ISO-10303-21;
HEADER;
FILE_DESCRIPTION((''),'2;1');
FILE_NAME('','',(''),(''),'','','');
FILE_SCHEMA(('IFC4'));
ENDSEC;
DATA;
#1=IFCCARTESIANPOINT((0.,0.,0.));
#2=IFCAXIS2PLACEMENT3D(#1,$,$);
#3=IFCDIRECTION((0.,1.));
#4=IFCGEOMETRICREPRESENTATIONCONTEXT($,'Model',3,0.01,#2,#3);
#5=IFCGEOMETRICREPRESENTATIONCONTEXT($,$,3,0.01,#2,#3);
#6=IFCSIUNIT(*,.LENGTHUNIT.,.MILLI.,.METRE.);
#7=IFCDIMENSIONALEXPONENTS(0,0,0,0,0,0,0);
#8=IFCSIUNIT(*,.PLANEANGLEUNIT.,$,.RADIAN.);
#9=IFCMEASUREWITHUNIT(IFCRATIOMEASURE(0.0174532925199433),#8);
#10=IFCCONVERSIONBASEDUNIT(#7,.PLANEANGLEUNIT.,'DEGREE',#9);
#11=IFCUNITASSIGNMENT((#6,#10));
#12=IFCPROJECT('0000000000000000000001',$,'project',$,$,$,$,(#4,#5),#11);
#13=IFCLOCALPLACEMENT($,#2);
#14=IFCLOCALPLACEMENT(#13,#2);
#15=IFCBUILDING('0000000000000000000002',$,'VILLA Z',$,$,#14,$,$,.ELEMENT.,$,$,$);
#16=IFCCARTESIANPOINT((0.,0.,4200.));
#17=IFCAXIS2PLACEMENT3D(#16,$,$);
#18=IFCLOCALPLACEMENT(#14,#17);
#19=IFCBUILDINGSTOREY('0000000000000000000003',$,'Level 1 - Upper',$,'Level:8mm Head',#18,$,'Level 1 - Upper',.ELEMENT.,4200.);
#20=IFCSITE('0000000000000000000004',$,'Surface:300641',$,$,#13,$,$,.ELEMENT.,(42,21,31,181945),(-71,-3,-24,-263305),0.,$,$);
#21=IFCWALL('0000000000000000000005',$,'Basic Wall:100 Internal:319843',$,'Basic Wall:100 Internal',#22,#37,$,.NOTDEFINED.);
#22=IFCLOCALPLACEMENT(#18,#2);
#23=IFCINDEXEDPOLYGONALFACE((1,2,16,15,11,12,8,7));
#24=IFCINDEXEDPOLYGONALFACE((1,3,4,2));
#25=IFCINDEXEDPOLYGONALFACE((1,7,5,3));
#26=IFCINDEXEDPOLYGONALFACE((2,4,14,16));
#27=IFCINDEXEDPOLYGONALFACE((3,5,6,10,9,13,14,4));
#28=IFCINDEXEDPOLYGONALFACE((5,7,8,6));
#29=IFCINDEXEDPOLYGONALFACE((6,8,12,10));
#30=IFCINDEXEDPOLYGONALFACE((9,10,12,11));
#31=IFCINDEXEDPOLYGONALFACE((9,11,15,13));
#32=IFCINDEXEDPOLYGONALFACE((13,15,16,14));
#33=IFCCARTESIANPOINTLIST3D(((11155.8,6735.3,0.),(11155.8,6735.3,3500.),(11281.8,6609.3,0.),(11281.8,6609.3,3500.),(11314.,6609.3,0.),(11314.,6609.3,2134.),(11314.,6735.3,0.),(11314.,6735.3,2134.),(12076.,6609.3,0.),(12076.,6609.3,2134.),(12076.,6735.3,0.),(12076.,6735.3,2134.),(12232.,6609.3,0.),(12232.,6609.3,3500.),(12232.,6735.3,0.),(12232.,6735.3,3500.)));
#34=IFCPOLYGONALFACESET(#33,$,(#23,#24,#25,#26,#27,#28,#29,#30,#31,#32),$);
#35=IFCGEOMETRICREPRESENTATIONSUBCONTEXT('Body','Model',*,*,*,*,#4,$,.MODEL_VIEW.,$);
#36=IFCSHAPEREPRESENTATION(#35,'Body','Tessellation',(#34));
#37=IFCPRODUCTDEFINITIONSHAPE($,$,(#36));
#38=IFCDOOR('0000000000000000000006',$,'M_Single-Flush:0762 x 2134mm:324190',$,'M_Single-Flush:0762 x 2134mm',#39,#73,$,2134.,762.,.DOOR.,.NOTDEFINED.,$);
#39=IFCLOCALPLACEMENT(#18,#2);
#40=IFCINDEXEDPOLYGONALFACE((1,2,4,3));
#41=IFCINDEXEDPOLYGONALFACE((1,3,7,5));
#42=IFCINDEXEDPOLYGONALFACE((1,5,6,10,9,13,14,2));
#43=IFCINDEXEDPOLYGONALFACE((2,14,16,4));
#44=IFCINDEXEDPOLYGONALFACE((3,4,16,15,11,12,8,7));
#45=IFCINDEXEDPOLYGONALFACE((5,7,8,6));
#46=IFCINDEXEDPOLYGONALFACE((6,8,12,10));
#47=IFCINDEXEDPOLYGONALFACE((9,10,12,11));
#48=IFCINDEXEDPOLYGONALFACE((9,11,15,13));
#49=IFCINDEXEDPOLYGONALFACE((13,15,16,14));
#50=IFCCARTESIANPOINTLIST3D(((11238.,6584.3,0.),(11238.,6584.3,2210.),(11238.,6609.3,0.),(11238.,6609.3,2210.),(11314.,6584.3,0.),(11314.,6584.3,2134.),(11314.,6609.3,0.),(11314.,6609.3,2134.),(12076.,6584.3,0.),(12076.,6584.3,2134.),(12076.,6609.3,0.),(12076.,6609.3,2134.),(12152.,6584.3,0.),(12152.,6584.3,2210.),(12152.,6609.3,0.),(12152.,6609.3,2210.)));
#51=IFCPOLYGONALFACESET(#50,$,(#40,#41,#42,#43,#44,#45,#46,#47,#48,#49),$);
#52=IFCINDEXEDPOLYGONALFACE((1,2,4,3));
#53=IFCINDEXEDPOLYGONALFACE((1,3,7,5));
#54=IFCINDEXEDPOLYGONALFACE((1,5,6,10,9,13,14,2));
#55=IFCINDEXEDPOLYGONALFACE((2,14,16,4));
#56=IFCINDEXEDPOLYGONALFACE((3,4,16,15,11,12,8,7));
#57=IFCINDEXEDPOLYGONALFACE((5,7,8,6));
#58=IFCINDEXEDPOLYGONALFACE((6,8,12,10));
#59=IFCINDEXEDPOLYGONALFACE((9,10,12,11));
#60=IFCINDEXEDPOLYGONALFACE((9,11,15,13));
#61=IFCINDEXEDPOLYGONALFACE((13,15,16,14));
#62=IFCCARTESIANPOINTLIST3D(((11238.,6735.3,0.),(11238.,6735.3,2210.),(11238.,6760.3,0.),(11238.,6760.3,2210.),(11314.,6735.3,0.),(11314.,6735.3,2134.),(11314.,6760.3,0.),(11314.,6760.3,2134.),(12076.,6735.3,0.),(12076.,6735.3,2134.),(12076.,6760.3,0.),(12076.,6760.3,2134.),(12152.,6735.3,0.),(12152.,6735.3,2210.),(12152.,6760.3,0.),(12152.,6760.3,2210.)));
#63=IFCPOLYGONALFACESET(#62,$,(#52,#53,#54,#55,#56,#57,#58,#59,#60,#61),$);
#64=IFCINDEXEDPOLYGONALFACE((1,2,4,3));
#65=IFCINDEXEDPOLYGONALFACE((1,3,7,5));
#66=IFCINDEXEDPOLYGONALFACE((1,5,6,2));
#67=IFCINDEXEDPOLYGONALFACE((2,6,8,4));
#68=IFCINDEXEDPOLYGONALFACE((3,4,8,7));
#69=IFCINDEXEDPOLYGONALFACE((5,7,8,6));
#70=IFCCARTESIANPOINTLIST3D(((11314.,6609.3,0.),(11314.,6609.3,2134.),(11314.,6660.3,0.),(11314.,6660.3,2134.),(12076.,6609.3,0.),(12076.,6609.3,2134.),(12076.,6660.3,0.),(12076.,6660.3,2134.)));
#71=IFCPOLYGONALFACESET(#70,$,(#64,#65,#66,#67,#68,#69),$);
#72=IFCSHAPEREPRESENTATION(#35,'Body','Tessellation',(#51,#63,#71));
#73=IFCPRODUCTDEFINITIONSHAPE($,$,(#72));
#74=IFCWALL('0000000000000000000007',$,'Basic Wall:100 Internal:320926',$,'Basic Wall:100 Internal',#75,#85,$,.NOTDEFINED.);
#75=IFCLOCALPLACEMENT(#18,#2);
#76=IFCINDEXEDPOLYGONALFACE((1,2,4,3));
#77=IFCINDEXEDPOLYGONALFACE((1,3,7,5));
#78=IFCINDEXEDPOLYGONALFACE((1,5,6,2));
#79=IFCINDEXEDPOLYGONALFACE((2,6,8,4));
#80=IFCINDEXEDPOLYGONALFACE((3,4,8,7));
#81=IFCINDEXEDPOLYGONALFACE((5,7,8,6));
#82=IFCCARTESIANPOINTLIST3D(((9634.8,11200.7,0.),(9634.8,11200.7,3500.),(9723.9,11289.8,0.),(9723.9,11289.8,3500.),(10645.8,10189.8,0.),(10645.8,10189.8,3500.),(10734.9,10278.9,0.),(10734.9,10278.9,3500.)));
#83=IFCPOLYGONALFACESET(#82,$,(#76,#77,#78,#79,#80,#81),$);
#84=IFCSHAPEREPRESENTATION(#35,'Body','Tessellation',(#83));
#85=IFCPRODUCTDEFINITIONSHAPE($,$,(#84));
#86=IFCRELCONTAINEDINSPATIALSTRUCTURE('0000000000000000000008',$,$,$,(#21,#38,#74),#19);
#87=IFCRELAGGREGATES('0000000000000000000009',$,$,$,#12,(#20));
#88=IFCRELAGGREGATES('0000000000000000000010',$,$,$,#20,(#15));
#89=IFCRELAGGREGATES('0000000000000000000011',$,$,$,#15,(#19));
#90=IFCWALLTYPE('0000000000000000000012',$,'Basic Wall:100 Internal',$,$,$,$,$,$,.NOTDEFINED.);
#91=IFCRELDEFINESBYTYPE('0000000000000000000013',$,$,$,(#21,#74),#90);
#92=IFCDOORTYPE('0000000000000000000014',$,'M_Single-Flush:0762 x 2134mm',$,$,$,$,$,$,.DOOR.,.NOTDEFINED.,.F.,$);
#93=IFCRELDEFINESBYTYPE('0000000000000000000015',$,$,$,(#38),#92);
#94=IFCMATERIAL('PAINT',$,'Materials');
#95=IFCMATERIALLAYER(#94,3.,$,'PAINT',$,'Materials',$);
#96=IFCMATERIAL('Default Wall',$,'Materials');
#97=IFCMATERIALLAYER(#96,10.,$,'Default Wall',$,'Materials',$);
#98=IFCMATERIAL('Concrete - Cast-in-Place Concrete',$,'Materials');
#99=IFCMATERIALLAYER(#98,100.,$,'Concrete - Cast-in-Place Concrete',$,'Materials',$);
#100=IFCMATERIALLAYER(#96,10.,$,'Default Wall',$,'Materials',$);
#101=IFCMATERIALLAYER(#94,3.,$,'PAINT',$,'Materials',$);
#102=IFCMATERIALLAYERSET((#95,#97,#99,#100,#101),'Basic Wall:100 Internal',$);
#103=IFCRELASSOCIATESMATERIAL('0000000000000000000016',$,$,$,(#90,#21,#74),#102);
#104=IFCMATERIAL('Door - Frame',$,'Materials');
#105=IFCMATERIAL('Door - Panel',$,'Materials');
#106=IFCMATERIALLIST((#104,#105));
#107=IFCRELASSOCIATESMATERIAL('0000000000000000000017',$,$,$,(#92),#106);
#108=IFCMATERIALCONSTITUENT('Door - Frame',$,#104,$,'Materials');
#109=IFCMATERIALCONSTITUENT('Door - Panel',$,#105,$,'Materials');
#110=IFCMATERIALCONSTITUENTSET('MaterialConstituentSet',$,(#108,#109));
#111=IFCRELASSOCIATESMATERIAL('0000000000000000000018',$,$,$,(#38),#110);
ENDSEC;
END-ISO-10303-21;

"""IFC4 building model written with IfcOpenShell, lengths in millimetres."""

from ifc_helpers import new_model, entity, si_unit, converted_unit, direction, frame, frame_2d, origin, place, context, subcontext, project, spatial, polyline, rectangle, outline, extrude, clip, halfspace, source, transform, mapped, material, material_list, layer, layer_set, layer_usage, constituent, constituent_set, type_object, type_shapes, element, fill, save


model = new_model("IFC4")

# Units and contexts
model_context = context("Model", 3, precision=0.01, world=origin(), true_north=direction((0.0, 1.0)))
context_of_model = context(None, 3, precision=0.01, world=origin(), true_north=direction((0.0, 1.0)))
body_context = subcontext(model_context, "Body", "Model", "MODEL_VIEW")
ifc_project = project(units=[si_unit("LENGTHUNIT", "METRE", prefix="MILLI"), converted_unit("PLANEANGLEUNIT", "DEGREE", entity("IfcRatioMeasure", 0.0174532925199433), si_unit("PLANEANGLEUNIT", "RADIAN"), dimensions=[0, 0, 0, 0, 0, 0, 0])], contexts=[model_context, context_of_model])

# Site, building, storey
site_placement = place(None, origin())
site = spatial("IfcSite", under=ifc_project, at=site_placement, Name="Surface:300641", CompositionType="ELEMENT", RefLatitude=(42, 21, 31, 181945), RefLongitude=(-71, -3, -24, -263305), RefElevation=0.0)
building_placement = place(site_placement, origin())
building = spatial("IfcBuilding", under=site, at=building_placement, Name="VILLA Z", CompositionType="ELEMENT")
storey_placement = place(building_placement, frame((0.0, 0.0, 4200.0)))
storey = spatial("IfcBuildingStorey", under=building, at=storey_placement, Name="Level 1 - Upper", ObjectType="Level:8mm Head", LongName="Level 1 - Upper", CompositionType="ELEMENT", Elevation=4200.0)

# Shared definitions
ifc_material_1 = material(Name="PAINT", Category="Materials")
ifc_material_2 = material(Name="Concrete - Cast-in-Place Concrete", Category="Materials")
ifc_material_3 = material(Name="Default Wall", Category="Materials")

# Shared definitions
ifc_layer_1 = layer(ifc_material_1, 3.0, Name="PAINT", Category="Materials")
ifc_layer_2 = layer(ifc_material_3, 10.0, Name="Default Wall", Category="Materials")
ifc_layer_3 = layer(ifc_material_2, 100.0, Name="Concrete - Cast-in-Place Concrete", Category="Materials")
ifc_layer_4 = layer(ifc_material_3, 10.0, Name="Default Wall", Category="Materials")
ifc_layer_5 = layer(ifc_material_1, 3.0, Name="PAINT", Category="Materials")
ifc_layer_set_1 = layer_set([ifc_layer_1, ifc_layer_2, ifc_layer_3, ifc_layer_4, ifc_layer_5], Name="Basic Wall:100 Internal")
wall_type_1 = type_object("IfcWallType", Name="Basic Wall:100 Internal", PredefinedType="NOTDEFINED", material=ifc_layer_set_1)

# Shared definitions
ifc_material_4 = material(Name="Door - Frame", Category="Materials")
ifc_material_5 = material(Name="Door - Panel", Category="Materials")
ifc_material_list = material_list([ifc_material_4, ifc_material_5])
door_type = type_object("IfcDoorType", Name="M_Single-Flush:0762 x 2134mm", OperationType="NOTDEFINED", ParameterTakesPrecedence=False, PredefinedType="DOOR", material=ifc_material_list)
shared_shape_1 = source(origin(), body_context, "Body", "SweptSolid", [
    extrude(outline(polyline([(-457.0, -1124.0), (457.0, -1124.0), (457.0, 1086.0), (381.0, 1086.0), (381.0, -1048.0), (-381.0, -1048.0), (-381.0, 1086.0), (-457.0, 1086.0), (-457.0, -1124.0)])), frame((381.0, 151.0, 1086.0), z_axis=(0.0, -1.0, 0.0), x_axis=(-1.0, 0.0, 0.0)), (0.0, 0.0, 1.0), 25.0),
    extrude(outline(polyline([(-1124.0, -457.0), (1086.0, -457.0), (1086.0, -381.0), (-1048.0, -381.0), (-1048.0, 381.0), (1086.0, 381.0), (1086.0, 457.0), (-1124.0, 457.0), (-1124.0, -457.0)])), frame((381.0, 0.0, 1086.0), z_axis=(0.0, -1.0, 0.0), x_axis=(0.0, 0.0, -1.0)), (0.0, 0.0, 1.0), 25.0),
    extrude(rectangle(XDim=762.0, YDim=51.0, at=frame_2d((0.0, 0.0), x_axis=(1.0, 0.0))), frame((381.0, 100.5, 0.0)), (0.0, 0.0, 1.0), 2134.0),
])
type_shapes(door_type, [shared_shape_1])

# Wall, opening, door
ifc_layer_usage_1 = layer_usage(ifc_layer_set_1, "AXIS2", "NEGATIVE", 63.0)
wall_1_placement = place(storey_placement, frame((11155.8, 6672.3, 0.0)))
wall_1 = element("IfcWall", 1, at=wall_1_placement, inside=storey, type_object=wall_type_1, material=ifc_layer_usage_1, Name="Basic Wall:100 Internal:319843", ObjectType="Basic Wall:100 Internal", PredefinedType="NOTDEFINED", context=body_context, shape_type="Clipping", body=[
    clip(extrude(outline(polyline([(126.0, -63.0), (1076.2, -63.0), (1076.2, 63.0), (0.0, 63.0), (126.0, -63.0)])), origin(), (0.0, 0.0, 1.0), 3500.0), halfspace(origin(), True)),
])
opening_1_placement = place(wall_1_placement, frame((920.2, 63.0, 0.0)))
opening_1 = element("IfcOpeningElement", 2, at=opening_1_placement, cuts=wall_1, ObjectType="Opening", PredefinedType="OPENING", context=body_context, shape_type="SweptSolid", body=[
    extrude(rectangle(XDim=762.0, YDim=2134.0, at=frame_2d((1067.0, 381.0), x_axis=(0.0, -1.0))), frame((0.0, 0.0, 0.0), z_axis=(0.0, -1.0, 0.0), x_axis=(0.0, 0.0, 1.0)), (0.0, 0.0, 1.0), 126.0),
])
ifc_constituent_1 = constituent(ifc_material_4, Name="Door - Frame", Category="Materials")
ifc_constituent_2 = constituent(ifc_material_5, Name="Door - Panel", Category="Materials")
ifc_constituent_set_1 = constituent_set(constituents=[ifc_constituent_1, ifc_constituent_2], Name="MaterialConstituentSet")
door_1_placement = place(opening_1_placement, frame((0.0, 0.0, 0.0), z_axis=(0.0, 0.0, 1.0), x_axis=(-1.0, 0.0, 0.0)))
door_1 = element("IfcDoor", 3, at=door_1_placement, inside=storey, type_object=door_type, material=ifc_constituent_set_1, Name="M_Single-Flush:0762 x 2134mm:324190", ObjectType="M_Single-Flush:0762 x 2134mm", OperationType="NOTDEFINED", OverallHeight=2134.0, OverallWidth=762.0, PredefinedType="DOOR", context=body_context, shape_type="MappedRepresentation", body=[
    mapped(shared_shape_1, transform((0.0, 0.0, 0.0), scale=1.0)),
])
fill(opening_1, door_1)

# Wall
ifc_layer_usage_2 = layer_usage(ifc_layer_set_1, "AXIS2", "NEGATIVE", 63.0)
wall_2_placement = place(storey_placement, frame((10690.3, 10234.3, 0.0), z_axis=(0.0, 0.0, 1.0), x_axis=(-0.707107, 0.707107, 0.0)))
element("IfcWall", 4, at=wall_2_placement, inside=storey, type_object=wall_type_1, material=ifc_layer_usage_2, Name="Basic Wall:100 Internal:320926", ObjectType="Basic Wall:100 Internal", PredefinedType="NOTDEFINED", context=body_context, shape_type="Clipping", body=[
    clip(extrude(rectangle(XDim=1429.7, YDim=126.0, at=frame_2d((714.9, 0.0), x_axis=(-1.0, 0.0))), origin(), (0.0, 0.0, 1.0), 3500.0), halfspace(origin(), True)),
])

save(model, "model.ifc")
